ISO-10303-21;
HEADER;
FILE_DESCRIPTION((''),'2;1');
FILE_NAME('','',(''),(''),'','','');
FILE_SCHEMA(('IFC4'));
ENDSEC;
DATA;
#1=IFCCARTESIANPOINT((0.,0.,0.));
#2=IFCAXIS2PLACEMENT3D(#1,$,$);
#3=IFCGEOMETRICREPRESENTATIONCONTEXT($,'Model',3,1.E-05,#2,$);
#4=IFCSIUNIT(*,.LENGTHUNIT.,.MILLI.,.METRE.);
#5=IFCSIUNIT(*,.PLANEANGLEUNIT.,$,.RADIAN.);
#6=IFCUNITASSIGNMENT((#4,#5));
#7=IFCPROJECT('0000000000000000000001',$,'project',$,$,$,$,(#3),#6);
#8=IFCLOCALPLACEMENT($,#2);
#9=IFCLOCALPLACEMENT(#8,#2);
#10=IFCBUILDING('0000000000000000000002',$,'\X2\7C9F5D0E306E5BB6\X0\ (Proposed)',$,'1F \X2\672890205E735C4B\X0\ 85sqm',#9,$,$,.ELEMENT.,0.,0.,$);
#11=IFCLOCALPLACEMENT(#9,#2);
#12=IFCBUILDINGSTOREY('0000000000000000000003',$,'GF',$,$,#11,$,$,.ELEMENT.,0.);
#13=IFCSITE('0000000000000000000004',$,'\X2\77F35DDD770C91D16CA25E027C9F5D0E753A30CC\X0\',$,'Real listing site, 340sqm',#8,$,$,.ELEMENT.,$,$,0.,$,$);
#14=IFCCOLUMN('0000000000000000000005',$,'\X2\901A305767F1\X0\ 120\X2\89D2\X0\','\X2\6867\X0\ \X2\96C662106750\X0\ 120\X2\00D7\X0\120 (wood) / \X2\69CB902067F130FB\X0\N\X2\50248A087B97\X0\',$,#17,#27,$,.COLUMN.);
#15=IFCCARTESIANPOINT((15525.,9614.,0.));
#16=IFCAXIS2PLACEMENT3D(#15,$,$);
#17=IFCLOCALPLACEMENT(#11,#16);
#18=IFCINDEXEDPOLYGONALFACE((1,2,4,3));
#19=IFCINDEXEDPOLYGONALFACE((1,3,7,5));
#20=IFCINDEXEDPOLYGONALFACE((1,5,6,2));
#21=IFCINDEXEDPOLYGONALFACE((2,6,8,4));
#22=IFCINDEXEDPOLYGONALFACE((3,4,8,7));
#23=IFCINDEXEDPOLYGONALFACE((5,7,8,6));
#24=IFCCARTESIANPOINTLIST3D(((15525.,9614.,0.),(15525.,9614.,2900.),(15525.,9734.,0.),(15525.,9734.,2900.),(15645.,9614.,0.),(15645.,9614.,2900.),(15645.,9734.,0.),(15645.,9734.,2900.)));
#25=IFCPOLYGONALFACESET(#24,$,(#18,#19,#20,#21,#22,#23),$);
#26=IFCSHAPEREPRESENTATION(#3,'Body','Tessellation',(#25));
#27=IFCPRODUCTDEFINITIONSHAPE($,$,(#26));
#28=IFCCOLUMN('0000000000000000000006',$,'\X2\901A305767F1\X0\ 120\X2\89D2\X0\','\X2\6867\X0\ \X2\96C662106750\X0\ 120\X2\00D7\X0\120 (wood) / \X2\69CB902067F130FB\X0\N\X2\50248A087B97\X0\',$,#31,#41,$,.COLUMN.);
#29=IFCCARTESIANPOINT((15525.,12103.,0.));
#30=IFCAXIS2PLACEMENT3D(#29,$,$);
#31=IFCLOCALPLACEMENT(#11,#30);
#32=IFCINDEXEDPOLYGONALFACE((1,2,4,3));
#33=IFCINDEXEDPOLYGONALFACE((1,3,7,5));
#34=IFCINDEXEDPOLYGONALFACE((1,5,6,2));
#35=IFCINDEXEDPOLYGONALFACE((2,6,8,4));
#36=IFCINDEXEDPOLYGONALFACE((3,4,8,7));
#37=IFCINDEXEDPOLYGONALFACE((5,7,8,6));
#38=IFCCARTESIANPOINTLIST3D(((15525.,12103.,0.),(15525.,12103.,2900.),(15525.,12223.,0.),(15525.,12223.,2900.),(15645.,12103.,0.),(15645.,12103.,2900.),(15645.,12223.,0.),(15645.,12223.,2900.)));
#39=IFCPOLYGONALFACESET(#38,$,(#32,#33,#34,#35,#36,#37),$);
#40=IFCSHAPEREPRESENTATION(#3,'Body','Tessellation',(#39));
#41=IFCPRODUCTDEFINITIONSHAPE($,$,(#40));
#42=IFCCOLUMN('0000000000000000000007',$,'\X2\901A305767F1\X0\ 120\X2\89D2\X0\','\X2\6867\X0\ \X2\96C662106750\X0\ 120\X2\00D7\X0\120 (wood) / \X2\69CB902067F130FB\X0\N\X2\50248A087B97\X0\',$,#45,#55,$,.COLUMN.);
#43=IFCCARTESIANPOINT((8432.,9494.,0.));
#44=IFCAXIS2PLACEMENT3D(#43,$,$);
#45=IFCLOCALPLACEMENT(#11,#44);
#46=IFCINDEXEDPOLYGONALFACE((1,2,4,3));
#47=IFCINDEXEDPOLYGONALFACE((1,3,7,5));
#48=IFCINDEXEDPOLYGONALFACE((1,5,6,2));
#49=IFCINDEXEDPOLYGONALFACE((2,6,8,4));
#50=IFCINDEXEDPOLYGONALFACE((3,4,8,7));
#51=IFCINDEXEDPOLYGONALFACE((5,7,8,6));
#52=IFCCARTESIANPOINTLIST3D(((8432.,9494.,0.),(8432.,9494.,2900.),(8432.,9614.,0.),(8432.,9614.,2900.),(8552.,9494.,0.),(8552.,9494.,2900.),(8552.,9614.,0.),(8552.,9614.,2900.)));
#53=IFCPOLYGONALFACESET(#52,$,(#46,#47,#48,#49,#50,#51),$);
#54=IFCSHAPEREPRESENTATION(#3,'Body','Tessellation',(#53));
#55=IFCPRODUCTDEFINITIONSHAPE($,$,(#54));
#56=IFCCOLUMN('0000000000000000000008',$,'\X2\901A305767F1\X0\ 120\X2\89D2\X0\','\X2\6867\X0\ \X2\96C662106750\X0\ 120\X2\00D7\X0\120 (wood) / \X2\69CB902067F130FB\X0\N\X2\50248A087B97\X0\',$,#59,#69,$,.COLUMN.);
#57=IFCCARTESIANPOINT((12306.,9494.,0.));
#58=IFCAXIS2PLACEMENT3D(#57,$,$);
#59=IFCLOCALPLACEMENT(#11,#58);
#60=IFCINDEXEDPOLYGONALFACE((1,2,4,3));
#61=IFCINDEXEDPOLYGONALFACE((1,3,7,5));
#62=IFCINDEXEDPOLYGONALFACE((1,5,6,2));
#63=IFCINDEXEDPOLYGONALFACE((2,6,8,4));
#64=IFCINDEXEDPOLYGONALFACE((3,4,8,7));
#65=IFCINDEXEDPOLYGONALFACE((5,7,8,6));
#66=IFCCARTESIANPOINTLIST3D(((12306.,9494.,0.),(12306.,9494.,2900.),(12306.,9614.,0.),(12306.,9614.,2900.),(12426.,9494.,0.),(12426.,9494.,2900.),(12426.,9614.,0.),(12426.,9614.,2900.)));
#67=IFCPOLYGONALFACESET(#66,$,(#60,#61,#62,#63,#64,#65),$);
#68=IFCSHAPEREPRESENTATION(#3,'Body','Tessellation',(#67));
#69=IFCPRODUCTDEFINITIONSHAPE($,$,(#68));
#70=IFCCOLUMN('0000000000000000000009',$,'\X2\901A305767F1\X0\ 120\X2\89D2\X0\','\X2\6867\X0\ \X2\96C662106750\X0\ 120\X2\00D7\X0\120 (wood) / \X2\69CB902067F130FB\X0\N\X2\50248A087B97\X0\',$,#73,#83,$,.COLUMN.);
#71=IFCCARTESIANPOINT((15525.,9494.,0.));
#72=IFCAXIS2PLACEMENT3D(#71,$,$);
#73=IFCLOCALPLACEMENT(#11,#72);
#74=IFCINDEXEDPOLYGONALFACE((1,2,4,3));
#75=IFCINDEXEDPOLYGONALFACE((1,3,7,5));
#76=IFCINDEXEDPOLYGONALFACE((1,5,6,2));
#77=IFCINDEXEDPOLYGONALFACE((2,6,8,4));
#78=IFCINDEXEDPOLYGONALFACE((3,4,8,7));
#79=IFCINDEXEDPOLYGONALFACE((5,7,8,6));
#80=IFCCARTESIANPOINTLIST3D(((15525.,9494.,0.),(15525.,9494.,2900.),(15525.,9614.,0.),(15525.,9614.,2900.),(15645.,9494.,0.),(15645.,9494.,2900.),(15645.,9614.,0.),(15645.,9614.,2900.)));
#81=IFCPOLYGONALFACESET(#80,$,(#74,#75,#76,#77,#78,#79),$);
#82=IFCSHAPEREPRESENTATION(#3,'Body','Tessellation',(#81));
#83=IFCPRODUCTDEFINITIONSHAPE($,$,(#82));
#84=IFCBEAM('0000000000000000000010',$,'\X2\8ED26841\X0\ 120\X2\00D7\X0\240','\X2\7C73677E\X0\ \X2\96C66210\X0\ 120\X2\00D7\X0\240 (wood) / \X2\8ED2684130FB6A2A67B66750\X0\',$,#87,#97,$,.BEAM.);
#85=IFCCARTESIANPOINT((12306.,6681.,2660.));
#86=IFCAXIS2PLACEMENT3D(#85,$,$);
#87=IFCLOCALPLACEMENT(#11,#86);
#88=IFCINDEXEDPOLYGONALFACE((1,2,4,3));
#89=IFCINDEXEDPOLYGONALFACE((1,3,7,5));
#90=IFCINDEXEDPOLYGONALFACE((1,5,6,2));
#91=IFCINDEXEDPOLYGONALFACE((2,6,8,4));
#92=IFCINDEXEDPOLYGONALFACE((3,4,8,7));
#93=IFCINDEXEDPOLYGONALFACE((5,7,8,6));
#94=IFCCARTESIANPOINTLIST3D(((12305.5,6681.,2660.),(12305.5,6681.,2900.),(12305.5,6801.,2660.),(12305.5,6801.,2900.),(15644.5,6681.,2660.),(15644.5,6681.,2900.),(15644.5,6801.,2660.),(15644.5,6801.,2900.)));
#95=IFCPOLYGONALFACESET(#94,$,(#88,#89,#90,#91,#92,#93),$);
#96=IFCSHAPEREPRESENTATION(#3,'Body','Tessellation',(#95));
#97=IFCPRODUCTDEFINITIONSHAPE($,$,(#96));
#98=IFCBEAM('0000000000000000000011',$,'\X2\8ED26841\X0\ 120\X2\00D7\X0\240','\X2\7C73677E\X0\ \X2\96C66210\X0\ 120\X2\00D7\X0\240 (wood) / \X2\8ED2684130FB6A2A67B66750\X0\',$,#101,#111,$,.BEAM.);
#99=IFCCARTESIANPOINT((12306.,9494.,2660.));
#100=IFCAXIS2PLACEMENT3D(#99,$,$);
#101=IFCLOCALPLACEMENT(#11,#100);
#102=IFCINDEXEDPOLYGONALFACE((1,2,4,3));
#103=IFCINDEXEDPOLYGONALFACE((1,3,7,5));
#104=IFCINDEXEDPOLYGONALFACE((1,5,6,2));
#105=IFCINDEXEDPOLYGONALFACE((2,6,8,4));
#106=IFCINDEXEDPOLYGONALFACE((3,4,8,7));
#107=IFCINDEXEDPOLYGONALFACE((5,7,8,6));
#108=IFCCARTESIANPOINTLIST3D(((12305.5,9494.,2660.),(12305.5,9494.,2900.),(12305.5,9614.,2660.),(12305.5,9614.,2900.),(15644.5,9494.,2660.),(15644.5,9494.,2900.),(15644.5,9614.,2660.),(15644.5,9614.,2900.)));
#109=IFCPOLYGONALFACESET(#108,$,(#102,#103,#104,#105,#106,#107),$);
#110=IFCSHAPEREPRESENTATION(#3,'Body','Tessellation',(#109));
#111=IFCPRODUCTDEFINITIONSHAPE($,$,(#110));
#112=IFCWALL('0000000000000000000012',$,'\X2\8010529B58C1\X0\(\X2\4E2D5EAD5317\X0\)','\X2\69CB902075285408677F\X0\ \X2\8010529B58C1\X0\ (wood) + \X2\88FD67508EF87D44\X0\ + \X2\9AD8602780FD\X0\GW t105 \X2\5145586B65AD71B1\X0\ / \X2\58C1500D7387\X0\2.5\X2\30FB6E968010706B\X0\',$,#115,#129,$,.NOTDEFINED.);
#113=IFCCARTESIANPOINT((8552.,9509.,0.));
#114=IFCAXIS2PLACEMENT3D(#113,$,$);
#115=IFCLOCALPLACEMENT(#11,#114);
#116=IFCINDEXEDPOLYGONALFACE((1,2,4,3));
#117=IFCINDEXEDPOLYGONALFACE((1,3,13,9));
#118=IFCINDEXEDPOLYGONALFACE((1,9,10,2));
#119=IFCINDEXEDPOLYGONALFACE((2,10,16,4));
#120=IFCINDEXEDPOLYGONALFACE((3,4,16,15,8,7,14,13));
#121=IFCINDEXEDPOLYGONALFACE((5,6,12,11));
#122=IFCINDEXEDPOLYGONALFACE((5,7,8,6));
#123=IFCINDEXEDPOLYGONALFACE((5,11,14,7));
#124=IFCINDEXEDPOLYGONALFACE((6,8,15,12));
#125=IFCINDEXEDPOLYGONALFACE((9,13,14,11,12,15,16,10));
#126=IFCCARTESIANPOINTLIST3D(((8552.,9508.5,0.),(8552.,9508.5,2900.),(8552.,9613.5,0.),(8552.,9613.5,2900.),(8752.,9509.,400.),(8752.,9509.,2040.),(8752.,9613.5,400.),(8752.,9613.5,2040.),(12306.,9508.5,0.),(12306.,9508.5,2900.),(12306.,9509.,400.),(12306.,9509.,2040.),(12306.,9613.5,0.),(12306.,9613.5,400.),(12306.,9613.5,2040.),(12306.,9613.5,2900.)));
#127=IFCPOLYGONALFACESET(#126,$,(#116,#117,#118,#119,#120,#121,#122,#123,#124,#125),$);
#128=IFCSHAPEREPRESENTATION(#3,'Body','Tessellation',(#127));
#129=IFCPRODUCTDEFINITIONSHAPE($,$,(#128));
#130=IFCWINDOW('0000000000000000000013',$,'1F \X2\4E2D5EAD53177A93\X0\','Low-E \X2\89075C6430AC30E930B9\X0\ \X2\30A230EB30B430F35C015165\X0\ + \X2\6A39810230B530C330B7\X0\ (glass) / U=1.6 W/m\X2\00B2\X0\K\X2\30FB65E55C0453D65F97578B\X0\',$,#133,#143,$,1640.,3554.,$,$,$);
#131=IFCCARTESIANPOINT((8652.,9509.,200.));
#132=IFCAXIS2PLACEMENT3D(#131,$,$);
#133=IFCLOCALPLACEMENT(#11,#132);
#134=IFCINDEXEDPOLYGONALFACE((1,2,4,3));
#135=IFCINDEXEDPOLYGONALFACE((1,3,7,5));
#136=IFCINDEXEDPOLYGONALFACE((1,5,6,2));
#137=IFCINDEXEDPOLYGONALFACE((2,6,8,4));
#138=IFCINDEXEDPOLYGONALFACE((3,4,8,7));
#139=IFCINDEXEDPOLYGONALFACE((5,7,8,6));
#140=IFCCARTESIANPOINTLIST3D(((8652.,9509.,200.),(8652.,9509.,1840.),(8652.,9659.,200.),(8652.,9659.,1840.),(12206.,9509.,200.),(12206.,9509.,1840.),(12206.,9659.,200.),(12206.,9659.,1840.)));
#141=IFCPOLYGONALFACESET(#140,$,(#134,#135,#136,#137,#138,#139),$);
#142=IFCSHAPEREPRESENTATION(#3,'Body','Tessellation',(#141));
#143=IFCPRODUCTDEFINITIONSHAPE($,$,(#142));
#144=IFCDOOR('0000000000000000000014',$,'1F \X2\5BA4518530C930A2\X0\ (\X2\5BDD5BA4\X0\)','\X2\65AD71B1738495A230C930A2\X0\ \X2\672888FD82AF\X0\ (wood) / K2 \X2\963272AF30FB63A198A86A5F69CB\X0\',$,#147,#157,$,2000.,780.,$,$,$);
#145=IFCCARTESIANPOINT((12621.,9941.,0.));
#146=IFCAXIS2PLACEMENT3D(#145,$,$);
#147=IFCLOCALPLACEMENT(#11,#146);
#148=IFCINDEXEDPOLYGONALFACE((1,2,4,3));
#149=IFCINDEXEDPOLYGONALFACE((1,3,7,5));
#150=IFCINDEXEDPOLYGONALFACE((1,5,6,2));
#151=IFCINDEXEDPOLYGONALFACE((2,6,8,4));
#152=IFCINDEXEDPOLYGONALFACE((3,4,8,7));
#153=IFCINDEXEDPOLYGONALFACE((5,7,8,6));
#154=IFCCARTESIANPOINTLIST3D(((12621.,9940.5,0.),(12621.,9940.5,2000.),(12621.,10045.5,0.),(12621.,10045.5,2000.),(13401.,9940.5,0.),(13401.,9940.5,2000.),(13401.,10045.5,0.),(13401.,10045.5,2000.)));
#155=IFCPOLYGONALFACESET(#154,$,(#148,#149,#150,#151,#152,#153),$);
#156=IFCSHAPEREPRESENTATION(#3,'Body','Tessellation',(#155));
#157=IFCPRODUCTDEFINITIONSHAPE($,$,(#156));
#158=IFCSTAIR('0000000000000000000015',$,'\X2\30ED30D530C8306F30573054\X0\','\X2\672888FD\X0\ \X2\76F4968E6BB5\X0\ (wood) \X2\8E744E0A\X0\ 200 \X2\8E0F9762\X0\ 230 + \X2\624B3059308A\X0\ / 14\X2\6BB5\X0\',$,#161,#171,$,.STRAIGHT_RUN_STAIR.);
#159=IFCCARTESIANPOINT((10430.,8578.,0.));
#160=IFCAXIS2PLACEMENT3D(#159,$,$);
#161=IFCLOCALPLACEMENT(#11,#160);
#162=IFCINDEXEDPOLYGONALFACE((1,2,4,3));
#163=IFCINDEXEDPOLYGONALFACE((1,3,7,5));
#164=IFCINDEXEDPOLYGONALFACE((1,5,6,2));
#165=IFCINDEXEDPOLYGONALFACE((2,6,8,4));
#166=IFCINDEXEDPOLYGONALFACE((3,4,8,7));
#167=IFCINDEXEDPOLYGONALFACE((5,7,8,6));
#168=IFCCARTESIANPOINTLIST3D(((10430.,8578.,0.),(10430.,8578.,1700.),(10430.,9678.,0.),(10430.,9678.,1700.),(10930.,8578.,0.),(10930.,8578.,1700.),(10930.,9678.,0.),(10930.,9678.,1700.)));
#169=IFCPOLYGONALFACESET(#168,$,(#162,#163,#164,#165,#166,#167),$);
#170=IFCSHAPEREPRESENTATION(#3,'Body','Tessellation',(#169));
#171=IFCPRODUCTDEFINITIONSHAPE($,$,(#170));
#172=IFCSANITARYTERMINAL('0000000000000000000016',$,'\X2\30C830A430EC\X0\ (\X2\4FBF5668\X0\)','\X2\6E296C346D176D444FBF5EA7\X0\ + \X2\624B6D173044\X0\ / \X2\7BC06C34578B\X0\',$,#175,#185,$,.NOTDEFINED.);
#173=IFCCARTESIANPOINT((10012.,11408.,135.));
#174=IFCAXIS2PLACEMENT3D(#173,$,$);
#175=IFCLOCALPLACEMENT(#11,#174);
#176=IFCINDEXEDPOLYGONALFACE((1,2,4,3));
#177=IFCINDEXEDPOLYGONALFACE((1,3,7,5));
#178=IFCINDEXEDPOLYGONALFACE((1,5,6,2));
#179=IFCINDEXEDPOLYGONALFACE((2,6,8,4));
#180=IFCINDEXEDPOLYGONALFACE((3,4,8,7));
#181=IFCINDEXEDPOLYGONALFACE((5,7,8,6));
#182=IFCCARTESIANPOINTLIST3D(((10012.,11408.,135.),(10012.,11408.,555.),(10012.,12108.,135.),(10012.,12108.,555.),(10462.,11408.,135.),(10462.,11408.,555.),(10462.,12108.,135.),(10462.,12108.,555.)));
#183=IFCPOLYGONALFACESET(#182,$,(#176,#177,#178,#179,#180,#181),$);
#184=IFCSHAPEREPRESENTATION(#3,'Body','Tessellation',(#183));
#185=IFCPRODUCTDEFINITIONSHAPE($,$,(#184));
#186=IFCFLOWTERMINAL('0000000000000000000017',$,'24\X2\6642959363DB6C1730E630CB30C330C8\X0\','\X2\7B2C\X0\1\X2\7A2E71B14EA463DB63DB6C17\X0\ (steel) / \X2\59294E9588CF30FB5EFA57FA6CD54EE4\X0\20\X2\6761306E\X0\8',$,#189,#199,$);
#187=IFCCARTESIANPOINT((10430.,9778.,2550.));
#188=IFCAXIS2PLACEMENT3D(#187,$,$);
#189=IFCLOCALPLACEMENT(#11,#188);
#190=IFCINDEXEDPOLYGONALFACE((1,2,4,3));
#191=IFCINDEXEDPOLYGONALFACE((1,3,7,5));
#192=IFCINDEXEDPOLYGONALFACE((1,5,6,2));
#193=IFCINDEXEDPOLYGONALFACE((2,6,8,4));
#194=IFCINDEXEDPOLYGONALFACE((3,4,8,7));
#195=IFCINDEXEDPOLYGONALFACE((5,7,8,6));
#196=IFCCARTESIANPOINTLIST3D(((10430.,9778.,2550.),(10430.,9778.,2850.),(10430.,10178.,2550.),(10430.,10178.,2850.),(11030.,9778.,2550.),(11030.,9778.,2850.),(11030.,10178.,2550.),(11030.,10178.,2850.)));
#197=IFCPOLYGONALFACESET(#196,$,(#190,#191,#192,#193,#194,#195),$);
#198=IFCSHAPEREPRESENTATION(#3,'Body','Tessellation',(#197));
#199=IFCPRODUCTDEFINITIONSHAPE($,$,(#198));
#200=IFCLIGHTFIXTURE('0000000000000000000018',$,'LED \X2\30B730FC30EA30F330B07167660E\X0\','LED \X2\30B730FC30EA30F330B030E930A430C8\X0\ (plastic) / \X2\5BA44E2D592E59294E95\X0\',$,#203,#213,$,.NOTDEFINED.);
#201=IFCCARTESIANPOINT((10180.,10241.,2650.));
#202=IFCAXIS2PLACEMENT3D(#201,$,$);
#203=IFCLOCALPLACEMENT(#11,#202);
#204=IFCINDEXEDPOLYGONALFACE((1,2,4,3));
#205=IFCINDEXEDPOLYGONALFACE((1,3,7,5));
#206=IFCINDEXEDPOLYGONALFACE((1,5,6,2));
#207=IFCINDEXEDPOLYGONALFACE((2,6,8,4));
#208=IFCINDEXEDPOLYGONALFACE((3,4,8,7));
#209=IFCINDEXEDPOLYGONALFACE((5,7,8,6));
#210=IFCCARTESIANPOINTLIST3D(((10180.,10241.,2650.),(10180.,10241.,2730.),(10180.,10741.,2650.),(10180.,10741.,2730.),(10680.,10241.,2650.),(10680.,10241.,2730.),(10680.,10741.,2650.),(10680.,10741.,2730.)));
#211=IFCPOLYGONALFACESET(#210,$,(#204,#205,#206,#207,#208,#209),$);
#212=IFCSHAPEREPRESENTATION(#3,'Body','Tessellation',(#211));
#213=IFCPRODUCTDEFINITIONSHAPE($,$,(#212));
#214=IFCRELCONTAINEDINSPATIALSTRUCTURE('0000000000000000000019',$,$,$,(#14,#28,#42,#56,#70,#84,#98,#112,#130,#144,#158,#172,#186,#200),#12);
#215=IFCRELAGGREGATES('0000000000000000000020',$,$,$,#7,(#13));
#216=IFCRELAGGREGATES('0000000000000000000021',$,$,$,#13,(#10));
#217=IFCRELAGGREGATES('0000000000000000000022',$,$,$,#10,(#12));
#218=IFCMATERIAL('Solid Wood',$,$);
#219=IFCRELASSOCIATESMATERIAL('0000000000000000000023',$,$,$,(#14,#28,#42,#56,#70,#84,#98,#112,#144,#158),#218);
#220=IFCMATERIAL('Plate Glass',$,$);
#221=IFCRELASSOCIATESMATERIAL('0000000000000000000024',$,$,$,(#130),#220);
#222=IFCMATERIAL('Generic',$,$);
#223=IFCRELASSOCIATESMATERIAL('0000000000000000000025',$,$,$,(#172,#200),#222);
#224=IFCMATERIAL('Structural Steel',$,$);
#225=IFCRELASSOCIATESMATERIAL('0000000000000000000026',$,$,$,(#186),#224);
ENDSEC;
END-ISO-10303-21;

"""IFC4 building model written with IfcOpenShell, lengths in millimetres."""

from ifc_helpers import new_model, si_unit, frame, frame_2d, origin, place, context, project, spatial, rectangle, extrude, material, element, fill, save


model = new_model("IFC4")

# Units and contexts
model_context = context("Model", 3, precision=1e-05, world=origin())
ifc_project = project(units=[si_unit("LENGTHUNIT", "METRE", prefix="MILLI"), si_unit("PLANEANGLEUNIT", "RADIAN")], contexts=[model_context])

# Site, building, storey
site_placement = place(None, origin())
site = spatial("IfcSite", under=ifc_project, at=site_placement, Name="石川県金沢市粟崎町ヌ", ObjectType="Real listing site, 340sqm", CompositionType="ELEMENT", RefElevation=0.0)
building_placement = place(site_placement, origin())
building = spatial("IfcBuilding", under=site, at=building_placement, Name="粟崎の家 (Proposed)", ObjectType="1F 木造平屋 85sqm", CompositionType="ELEMENT", ElevationOfRefHeight=0.0, ElevationOfTerrain=0.0)
storey_placement = place(building_placement, origin())
storey = spatial("IfcBuildingStorey", under=building, at=storey_placement, Name="GF", CompositionType="ELEMENT", Elevation=0.0)

# Columns
ifc_material_1 = material(Name="Solid Wood")
column_1_placement = place(storey_placement, frame((15525.0, 9614.0, 0.0)))
element("IfcColumn", 1, at=column_1_placement, inside=storey, material=ifc_material_1, Name="通し柱 120角", Description="桧 集成材 120×120 (wood) / 構造柱・N値計算", PredefinedType="COLUMN", context=model_context, shape_type="SweptSolid", body=[
    extrude(rectangle(XDim=120.0, YDim=120.0, at=frame_2d((60.0, 60.0))), frame((15525.0, 9614.0, 0.0)), (0.0, 0.0, 1.0), 2900.0),
])
column_2_placement = place(storey_placement, frame((15525.0, 12103.0, 0.0)))
element("IfcColumn", 2, at=column_2_placement, inside=storey, material=ifc_material_1, Name="通し柱 120角", Description="桧 集成材 120×120 (wood) / 構造柱・N値計算", PredefinedType="COLUMN", context=model_context, shape_type="SweptSolid", body=[
    extrude(rectangle(XDim=120.0, YDim=120.0, at=frame_2d((60.0, 60.0))), frame((15525.0, 12103.0, 0.0)), (0.0, 0.0, 1.0), 2900.0),
])
column_3_placement = place(storey_placement, frame((8432.0, 9494.0, 0.0)))
element("IfcColumn", 3, at=column_3_placement, inside=storey, material=ifc_material_1, Name="通し柱 120角", Description="桧 集成材 120×120 (wood) / 構造柱・N値計算", PredefinedType="COLUMN", context=model_context, shape_type="SweptSolid", body=[
    extrude(rectangle(XDim=120.0, YDim=120.0, at=frame_2d((60.0, 60.0))), frame((8432.0, 9494.0, 0.0)), (0.0, 0.0, 1.0), 2900.0),
])
column_4_placement = place(storey_placement, frame((12306.0, 9494.0, 0.0)))
element("IfcColumn", 4, at=column_4_placement, inside=storey, material=ifc_material_1, Name="通し柱 120角", Description="桧 集成材 120×120 (wood) / 構造柱・N値計算", PredefinedType="COLUMN", context=model_context, shape_type="SweptSolid", body=[
    extrude(rectangle(XDim=120.0, YDim=120.0, at=frame_2d((60.0, 60.0))), frame((12306.0, 9494.0, 0.0)), (0.0, 0.0, 1.0), 2900.0),
])
column_5_placement = place(storey_placement, frame((15525.0, 9494.0, 0.0)))
element("IfcColumn", 5, at=column_5_placement, inside=storey, material=ifc_material_1, Name="通し柱 120角", Description="桧 集成材 120×120 (wood) / 構造柱・N値計算", PredefinedType="COLUMN", context=model_context, shape_type="SweptSolid", body=[
    extrude(rectangle(XDim=120.0, YDim=120.0, at=frame_2d((60.0, 60.0))), frame((15525.0, 9494.0, 0.0)), (0.0, 0.0, 1.0), 2900.0),
])

# Beams
beam_1_placement = place(storey_placement, frame((12306.0, 6681.0, 2660.0)))
element("IfcBeam", 6, at=beam_1_placement, inside=storey, material=ifc_material_1, Name="軒桁 120×240", Description="米松 集成 120×240 (wood) / 軒桁・横架材", PredefinedType="BEAM", context=model_context, shape_type="SweptSolid", body=[
    extrude(rectangle(XDim=3339.0, YDim=120.0, at=frame_2d((1669.0, 60.0))), frame((12306.0, 6681.0, 2660.0)), (0.0, 0.0, 1.0), 240.0),
])
beam_2_placement = place(storey_placement, frame((12306.0, 9494.0, 2660.0)))
element("IfcBeam", 7, at=beam_2_placement, inside=storey, material=ifc_material_1, Name="軒桁 120×240", Description="米松 集成 120×240 (wood) / 軒桁・横架材", PredefinedType="BEAM", context=model_context, shape_type="SweptSolid", body=[
    extrude(rectangle(XDim=3339.0, YDim=120.0, at=frame_2d((1669.0, 60.0))), frame((12306.0, 9494.0, 2660.0)), (0.0, 0.0, 1.0), 240.0),
])

# Wall, opening, window
wall_1_placement = place(storey_placement, frame((8552.0, 9509.0, 0.0)))
wall_1 = element("IfcWall", 8, at=wall_1_placement, inside=storey, material=ifc_material_1, Name="耐力壁(中庭北)", Description="構造用合板 耐力壁 (wood) + 製材軸組 + 高性能GW t105 充填断熱 / 壁倍率2.5・準耐火", PredefinedType="NOTDEFINED", context=model_context, shape_type="SweptSolid", body=[
    extrude(rectangle(XDim=3754.0, YDim=105.0, at=frame_2d((1877.0, 52.0))), frame((8552.0, 9509.0, 0.0)), (0.0, 0.0, 1.0), 2900.0),
])
opening_placement = place(storey_placement, frame((8652.0, 9509.0, 200.0)))
opening = element("IfcOpeningElement", 9, at=opening_placement, cuts=wall_1, PredefinedType="NOTDEFINED", context=model_context, shape_type="SweptSolid", body=[
    extrude(rectangle(XDim=3554.0, YDim=150.0, at=frame_2d((1777.0, 75.0))), frame((8652.0, 9509.0, 200.0)), (0.0, 0.0, 1.0), 1640.0),
])
ifc_material_2 = material(Name="Plate Glass")
window_placement = place(storey_placement, frame((8652.0, 9509.0, 200.0)))
window = element("IfcWindow", 10, at=window_placement, inside=storey, material=ifc_material_2, Name="1F 中庭北窓", Description="Low-E 複層ガラス アルゴン封入 + 樹脂サッシ (glass) / U=1.6 W/m²K・日射取得型", OverallHeight=1640.0, OverallWidth=3554.0, context=model_context, shape_type="SweptSolid", body=[
    extrude(rectangle(XDim=3554.0, YDim=150.0, at=frame_2d((1777.0, 75.0))), frame((8652.0, 9509.0, 200.0)), (0.0, 0.0, 1.0), 1640.0),
])
fill(opening, window)

# Door
door_placement = place(storey_placement, frame((12621.0, 9941.0, 0.0)))
element("IfcDoor", 11, at=door_placement, inside=storey, material=ifc_material_1, Name="1F 室内ドア (寝室)", Description="断熱玄関ドア 木製芯 (wood) / K2 防犯・採風機構", OverallHeight=2000.0, OverallWidth=780.0, context=model_context, shape_type="SweptSolid", body=[
    extrude(rectangle(XDim=780.0, YDim=105.0, at=frame_2d((390.0, 52.0))), frame((12621.0, 9941.0, 0.0)), (0.0, 0.0, 1.0), 2000.0),
])

# Stair
stair_placement = place(storey_placement, frame((10430.0, 8578.0, 0.0)))
element("IfcStair", 12, at=stair_placement, inside=storey, material=ifc_material_1, Name="ロフトはしご", Description="木製 直階段 (wood) 蹴上 200 踏面 230 + 手すり / 14段", PredefinedType="STRAIGHT_RUN_STAIR", context=model_context, shape_type="SweptSolid", body=[
    extrude(rectangle(XDim=500.0, YDim=1100.0, at=frame_2d((250.0, 550.0))), frame((10430.0, 8578.0, 0.0)), (0.0, 0.0, 1.0), 1700.0),
])

# Shared definitions
ifc_material_3 = material(Name="Generic")

# Sanitary terminal
sanitary_terminal_placement = place(storey_placement, frame((10012.0, 11408.0, 135.0)))
element("IfcSanitaryTerminal", 13, at=sanitary_terminal_placement, inside=storey, material=ifc_material_3, Name="トイレ (便器)", Description="温水洗浄便座 + 手洗い / 節水型", PredefinedType="NOTDEFINED", context=model_context, shape_type="SweptSolid", body=[
    extrude(rectangle(XDim=450.0, YDim=700.0, at=frame_2d((225.0, 350.0))), frame((10012.0, 11408.0, 135.0)), (0.0, 0.0, 1.0), 420.0),
])

# Flow terminal
ifc_material_4 = material(Name="Structural Steel")
flow_terminal_placement = place(storey_placement, frame((10430.0, 9778.0, 2550.0)))
element("IfcFlowTerminal", 14, at=flow_terminal_placement, inside=storey, material=ifc_material_4, Name="24時間換気ユニット", Description="第1種熱交換換気 (steel) / 天井裏・建基法令20条の8", context=model_context, shape_type="SweptSolid", body=[
    extrude(rectangle(XDim=600.0, YDim=400.0, at=frame_2d((300.0, 200.0))), frame((10430.0, 9778.0, 2550.0)), (0.0, 0.0, 1.0), 300.0),
])

# Light fixture
light_fixture_1_placement = place(storey_placement, frame((10180.0, 10241.0, 2650.0)))
element("IfcLightFixture", 15, at=light_fixture_1_placement, inside=storey, material=ifc_material_3, Name="LED シーリング照明", Description="LED シーリングライト (plastic) / 室中央天井", PredefinedType="NOTDEFINED", context=model_context, shape_type="SweptSolid", body=[
    extrude(rectangle(XDim=500.0, YDim=500.0, at=frame_2d((250.0, 250.0))), frame((10180.0, 10241.0, 2650.0)), (0.0, 0.0, 1.0), 80.0),
])

save(model, "model.ifc")
